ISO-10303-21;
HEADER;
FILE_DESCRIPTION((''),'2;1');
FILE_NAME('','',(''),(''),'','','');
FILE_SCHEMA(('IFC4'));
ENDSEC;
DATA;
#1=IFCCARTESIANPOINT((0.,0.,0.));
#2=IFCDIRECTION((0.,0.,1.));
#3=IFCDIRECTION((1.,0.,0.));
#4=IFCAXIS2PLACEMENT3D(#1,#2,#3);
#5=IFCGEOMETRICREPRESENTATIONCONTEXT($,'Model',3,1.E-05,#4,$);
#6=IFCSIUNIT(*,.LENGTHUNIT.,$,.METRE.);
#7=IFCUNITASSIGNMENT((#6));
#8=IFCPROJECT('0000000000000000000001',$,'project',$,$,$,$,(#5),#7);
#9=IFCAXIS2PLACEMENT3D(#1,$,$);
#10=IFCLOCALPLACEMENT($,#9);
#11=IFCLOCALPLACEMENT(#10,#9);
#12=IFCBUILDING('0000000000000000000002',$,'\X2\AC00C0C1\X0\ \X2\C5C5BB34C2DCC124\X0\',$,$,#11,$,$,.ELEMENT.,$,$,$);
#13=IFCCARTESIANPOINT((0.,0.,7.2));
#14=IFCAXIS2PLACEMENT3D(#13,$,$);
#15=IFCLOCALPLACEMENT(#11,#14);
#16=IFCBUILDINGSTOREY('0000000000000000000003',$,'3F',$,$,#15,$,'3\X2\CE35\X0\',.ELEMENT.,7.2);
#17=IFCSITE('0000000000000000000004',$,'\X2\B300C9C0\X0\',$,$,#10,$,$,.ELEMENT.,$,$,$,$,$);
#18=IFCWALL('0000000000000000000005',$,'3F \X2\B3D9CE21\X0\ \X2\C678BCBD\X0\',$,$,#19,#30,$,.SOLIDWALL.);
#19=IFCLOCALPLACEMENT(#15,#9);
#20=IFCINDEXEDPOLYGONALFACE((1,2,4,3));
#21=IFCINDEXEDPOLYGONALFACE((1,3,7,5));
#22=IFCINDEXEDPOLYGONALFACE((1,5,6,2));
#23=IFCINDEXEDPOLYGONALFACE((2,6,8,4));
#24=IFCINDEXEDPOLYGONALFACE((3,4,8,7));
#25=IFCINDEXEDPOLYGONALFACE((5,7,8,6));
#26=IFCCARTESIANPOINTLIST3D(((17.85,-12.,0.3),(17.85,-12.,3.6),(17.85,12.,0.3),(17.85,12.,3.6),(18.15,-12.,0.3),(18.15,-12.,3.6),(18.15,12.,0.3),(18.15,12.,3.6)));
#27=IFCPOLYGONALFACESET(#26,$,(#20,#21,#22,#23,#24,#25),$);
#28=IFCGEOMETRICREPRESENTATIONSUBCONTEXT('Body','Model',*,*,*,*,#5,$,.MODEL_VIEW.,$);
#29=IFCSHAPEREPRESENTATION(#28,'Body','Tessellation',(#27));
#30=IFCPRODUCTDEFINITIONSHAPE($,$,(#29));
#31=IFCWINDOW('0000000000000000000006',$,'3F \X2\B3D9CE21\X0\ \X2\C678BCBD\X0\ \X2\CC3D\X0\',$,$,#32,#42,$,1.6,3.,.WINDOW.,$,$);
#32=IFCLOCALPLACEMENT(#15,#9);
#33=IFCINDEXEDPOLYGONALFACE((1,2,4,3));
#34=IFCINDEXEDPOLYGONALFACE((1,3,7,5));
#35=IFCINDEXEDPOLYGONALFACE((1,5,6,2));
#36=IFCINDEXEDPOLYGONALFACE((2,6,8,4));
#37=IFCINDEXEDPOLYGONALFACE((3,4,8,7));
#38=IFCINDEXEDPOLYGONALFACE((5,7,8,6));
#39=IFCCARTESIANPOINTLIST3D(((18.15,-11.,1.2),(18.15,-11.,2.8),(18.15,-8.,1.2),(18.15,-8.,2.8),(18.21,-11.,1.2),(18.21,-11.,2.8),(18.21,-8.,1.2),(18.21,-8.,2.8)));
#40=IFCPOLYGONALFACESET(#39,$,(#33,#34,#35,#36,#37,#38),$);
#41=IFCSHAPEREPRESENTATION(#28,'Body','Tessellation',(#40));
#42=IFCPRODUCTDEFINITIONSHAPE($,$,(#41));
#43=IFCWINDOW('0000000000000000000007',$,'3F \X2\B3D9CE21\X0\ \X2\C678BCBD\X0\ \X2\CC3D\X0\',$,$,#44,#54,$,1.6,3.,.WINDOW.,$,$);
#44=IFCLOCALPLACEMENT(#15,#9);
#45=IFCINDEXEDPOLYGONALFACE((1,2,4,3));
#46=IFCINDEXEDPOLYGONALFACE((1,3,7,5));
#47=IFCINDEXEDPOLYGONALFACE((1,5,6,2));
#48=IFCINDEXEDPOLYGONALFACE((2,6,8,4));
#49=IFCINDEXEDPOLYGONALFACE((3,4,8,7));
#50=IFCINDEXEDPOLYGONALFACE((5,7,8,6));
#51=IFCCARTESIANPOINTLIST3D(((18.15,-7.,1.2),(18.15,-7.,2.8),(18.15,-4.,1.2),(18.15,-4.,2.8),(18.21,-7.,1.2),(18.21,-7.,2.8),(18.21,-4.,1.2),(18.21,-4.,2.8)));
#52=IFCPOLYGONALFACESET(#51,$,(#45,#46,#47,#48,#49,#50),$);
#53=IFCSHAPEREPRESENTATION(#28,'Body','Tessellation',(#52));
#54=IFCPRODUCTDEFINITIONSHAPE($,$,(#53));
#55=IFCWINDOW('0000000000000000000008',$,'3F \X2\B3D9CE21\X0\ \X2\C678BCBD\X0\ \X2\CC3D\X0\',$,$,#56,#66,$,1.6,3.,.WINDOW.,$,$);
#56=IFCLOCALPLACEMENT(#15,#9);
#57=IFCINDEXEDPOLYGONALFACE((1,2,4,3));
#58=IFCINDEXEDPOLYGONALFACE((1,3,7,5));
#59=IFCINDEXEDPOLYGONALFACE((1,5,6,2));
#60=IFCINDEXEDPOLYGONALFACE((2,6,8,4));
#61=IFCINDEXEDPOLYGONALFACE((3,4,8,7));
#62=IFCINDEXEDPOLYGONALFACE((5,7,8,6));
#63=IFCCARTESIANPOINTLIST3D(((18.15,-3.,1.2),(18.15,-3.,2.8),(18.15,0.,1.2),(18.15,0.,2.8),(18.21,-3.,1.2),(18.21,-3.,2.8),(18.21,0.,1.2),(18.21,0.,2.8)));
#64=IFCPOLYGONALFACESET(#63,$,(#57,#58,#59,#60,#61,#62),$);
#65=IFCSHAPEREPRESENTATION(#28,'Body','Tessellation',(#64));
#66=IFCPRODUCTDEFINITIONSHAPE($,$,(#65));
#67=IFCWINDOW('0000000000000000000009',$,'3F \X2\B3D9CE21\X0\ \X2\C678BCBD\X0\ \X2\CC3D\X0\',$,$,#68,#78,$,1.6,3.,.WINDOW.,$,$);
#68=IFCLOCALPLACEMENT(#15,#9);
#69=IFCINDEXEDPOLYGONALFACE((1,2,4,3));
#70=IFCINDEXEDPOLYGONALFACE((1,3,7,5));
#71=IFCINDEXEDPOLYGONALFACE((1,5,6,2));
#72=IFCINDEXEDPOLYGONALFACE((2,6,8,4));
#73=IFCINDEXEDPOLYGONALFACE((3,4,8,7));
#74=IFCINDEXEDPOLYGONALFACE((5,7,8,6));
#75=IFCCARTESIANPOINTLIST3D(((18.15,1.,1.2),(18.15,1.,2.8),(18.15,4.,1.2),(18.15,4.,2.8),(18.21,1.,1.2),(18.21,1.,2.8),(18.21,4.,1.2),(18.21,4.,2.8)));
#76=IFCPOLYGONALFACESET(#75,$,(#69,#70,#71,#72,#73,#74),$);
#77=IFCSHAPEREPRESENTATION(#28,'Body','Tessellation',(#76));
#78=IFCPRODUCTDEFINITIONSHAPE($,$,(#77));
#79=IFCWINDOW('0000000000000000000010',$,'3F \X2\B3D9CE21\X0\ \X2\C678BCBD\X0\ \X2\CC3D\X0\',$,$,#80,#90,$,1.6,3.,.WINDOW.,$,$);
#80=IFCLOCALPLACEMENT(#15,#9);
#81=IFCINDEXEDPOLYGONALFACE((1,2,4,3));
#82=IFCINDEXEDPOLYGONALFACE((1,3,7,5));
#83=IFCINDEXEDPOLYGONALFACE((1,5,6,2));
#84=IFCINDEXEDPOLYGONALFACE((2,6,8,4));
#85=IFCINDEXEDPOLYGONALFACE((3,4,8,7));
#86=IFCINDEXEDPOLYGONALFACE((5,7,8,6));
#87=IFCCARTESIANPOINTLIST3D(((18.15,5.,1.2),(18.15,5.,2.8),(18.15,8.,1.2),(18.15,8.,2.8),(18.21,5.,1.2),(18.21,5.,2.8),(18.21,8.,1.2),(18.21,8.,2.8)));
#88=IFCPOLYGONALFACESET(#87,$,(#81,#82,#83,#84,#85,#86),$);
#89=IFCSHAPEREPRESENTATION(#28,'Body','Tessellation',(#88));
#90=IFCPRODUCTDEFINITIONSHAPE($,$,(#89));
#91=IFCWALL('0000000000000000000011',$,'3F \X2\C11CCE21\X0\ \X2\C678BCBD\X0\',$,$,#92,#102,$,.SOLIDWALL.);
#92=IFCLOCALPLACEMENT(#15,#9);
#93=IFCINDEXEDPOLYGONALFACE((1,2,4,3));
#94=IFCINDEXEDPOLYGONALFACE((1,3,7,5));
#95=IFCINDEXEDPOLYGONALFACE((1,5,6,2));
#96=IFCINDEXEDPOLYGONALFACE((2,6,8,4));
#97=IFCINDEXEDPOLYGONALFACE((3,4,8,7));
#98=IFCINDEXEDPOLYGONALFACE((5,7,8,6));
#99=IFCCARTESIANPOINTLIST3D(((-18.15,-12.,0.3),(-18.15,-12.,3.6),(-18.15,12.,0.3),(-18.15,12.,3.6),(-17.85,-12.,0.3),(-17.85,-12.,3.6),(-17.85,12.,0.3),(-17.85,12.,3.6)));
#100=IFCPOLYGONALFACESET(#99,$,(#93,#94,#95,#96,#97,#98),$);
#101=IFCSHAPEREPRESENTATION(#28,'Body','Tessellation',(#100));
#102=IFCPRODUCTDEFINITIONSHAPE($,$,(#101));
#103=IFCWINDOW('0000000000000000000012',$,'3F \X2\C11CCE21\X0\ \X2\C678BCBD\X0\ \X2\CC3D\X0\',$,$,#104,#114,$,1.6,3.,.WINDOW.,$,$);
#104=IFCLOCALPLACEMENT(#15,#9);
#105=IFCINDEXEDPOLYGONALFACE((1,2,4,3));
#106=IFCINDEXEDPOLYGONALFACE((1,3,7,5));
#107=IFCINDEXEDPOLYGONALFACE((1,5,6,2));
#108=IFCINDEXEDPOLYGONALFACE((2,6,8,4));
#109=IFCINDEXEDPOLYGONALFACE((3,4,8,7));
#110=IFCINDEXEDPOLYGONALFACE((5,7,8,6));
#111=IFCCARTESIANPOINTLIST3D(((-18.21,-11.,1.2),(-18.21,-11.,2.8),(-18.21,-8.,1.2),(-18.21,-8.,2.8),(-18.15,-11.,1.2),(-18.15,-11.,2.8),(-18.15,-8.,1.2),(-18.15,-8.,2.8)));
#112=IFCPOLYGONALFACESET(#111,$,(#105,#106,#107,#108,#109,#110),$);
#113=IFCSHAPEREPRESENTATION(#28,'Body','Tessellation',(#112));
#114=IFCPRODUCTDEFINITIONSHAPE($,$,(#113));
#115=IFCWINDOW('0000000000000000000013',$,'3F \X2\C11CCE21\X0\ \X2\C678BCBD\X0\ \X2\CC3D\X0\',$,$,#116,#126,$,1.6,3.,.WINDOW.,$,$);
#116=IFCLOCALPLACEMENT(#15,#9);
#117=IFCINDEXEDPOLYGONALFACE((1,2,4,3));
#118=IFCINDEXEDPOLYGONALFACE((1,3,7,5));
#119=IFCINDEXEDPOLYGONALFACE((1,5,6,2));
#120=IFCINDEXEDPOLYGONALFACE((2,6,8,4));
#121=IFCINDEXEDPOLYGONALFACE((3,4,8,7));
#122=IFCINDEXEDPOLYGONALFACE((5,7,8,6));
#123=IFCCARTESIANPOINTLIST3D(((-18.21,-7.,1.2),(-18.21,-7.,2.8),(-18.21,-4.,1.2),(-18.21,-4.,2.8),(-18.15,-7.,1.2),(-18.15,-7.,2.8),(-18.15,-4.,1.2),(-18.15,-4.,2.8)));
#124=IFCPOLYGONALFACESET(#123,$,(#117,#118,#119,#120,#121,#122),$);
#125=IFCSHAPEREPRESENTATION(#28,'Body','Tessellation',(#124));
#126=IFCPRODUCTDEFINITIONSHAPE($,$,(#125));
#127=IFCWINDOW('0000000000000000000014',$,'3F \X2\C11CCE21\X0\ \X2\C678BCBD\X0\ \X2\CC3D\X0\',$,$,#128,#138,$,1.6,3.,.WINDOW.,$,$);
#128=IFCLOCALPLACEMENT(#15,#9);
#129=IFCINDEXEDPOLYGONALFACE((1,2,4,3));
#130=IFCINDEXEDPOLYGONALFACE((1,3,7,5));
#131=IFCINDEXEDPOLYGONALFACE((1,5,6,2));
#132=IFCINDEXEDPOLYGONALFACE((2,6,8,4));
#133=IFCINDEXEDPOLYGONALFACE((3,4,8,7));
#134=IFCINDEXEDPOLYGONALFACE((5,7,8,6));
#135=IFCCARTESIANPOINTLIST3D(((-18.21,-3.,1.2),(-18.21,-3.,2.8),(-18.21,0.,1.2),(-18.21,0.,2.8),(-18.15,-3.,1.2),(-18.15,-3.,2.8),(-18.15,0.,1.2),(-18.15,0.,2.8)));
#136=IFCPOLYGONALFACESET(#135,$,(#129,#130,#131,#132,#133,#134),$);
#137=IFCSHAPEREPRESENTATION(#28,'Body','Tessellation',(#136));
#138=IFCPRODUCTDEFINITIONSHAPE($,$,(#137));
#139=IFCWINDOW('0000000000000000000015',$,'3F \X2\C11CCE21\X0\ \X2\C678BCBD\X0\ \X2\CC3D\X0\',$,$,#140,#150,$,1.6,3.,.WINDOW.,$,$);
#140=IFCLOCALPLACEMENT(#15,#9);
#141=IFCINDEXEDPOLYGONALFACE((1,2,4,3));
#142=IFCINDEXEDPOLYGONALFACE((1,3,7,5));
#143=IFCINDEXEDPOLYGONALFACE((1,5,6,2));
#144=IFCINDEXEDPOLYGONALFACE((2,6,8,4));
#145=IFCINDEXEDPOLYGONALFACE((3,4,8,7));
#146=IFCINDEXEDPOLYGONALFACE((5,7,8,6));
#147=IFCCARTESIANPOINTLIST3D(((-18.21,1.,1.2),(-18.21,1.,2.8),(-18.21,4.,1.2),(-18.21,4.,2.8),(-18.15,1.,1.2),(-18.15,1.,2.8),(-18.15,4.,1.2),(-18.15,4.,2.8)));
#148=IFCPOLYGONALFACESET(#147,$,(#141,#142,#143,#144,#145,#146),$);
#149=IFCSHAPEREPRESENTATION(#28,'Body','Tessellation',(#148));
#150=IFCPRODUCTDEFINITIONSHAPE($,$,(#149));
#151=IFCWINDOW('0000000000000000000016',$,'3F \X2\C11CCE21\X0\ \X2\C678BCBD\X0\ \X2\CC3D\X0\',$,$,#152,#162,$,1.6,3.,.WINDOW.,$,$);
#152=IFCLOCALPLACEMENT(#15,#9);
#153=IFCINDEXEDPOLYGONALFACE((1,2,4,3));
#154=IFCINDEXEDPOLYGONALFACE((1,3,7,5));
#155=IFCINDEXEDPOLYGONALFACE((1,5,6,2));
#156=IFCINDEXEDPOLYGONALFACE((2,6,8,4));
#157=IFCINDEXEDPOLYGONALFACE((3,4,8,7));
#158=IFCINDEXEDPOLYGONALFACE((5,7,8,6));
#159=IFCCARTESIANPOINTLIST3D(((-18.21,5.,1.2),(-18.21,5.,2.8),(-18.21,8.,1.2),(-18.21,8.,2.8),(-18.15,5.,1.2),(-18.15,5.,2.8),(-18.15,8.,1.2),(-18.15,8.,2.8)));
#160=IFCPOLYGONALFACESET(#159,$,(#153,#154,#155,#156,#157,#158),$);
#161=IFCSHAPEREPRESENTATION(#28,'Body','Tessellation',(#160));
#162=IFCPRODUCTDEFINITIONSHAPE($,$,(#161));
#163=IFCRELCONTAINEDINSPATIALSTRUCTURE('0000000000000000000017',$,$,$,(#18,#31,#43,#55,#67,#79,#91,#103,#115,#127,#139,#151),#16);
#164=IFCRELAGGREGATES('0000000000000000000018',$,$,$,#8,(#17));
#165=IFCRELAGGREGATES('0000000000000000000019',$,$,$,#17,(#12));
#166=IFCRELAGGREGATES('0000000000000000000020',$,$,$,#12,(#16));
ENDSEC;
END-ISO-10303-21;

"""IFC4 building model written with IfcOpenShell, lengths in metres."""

from ifc_helpers import new_model, si_unit, frame, origin, origin_with_axes, origin_2d, place, context, subcontext, project, spatial, rectangle, extrude, element, save


model = new_model("IFC4")

# Units and contexts
model_context = context("Model", 3, precision=1e-05, world=origin_with_axes())
body_context = subcontext(model_context, "Body", "Model", "MODEL_VIEW")
ifc_project = project(units=[si_unit("LENGTHUNIT", "METRE")], contexts=[model_context])

# Site, building, storey
site_placement = place(None, origin())
site = spatial("IfcSite", under=ifc_project, at=site_placement, Name="대지", CompositionType="ELEMENT")
building_placement = place(site_placement, origin())
building = spatial("IfcBuilding", under=site, at=building_placement, Name="가상 업무시설", CompositionType="ELEMENT")
storey_placement = place(building_placement, frame((0.0, 0.0, 7.2)))
storey = spatial("IfcBuildingStorey", under=building, at=storey_placement, Name="3F", LongName="3층", CompositionType="ELEMENT", Elevation=7.2)

# Wall
wall_1_placement = place(storey_placement, frame((18.0, 0.0, 0.3)))
element("IfcWall", 1, at=wall_1_placement, inside=storey, Name="3F 동측 외벽", PredefinedType="SOLIDWALL", context=body_context, shape_type="SweptSolid", body=[
    extrude(rectangle(XDim=0.3, YDim=24.0, at=origin_2d()), origin_with_axes(), (0.0, 0.0, 1.0), 3.3),
])

# Windows
for number, where, name in (
    (2, (18.18, -9.5, 1.2), "3F 동측 외벽 창"),
    (3, (18.18, -5.5, 1.2), "3F 동측 외벽 창"),
    (4, (18.18, -1.5, 1.2), "3F 동측 외벽 창"),
    (5, (18.18, 2.5, 1.2), "3F 동측 외벽 창"),
    (6, (18.18, 6.5, 1.2), "3F 동측 외벽 창"),
):
    element("IfcWindow", number, at=place(storey_placement, frame(where)), inside=storey, Name=name, OverallHeight=1.6, OverallWidth=3.0, PredefinedType="WINDOW", context=body_context, shape_type="SweptSolid", body=[
        extrude(rectangle(XDim=0.06, YDim=3.0, at=origin_2d()), origin_with_axes(), (0.0, 0.0, 1.0), 1.6),
    ])

# Wall
wall_2_placement = place(storey_placement, frame((-18.0, 0.0, 0.3)))
element("IfcWall", 7, at=wall_2_placement, inside=storey, Name="3F 서측 외벽", PredefinedType="SOLIDWALL", context=body_context, shape_type="SweptSolid", body=[
    extrude(rectangle(XDim=0.3, YDim=24.0, at=origin_2d()), origin_with_axes(), (0.0, 0.0, 1.0), 3.3),
])

# Windows
for number, where, name in (
    (8, (-18.18, -9.5, 1.2), "3F 서측 외벽 창"),
    (9, (-18.18, -5.5, 1.2), "3F 서측 외벽 창"),
    (10, (-18.18, -1.5, 1.2), "3F 서측 외벽 창"),
    (11, (-18.18, 2.5, 1.2), "3F 서측 외벽 창"),
    (12, (-18.18, 6.5, 1.2), "3F 서측 외벽 창"),
):
    element("IfcWindow", number, at=place(storey_placement, frame(where)), inside=storey, Name=name, OverallHeight=1.6, OverallWidth=3.0, PredefinedType="WINDOW", context=body_context, shape_type="SweptSolid", body=[
        extrude(rectangle(XDim=0.06, YDim=3.0, at=origin_2d()), origin_with_axes(), (0.0, 0.0, 1.0), 1.6),
    ])

save(model, "model.ifc")
